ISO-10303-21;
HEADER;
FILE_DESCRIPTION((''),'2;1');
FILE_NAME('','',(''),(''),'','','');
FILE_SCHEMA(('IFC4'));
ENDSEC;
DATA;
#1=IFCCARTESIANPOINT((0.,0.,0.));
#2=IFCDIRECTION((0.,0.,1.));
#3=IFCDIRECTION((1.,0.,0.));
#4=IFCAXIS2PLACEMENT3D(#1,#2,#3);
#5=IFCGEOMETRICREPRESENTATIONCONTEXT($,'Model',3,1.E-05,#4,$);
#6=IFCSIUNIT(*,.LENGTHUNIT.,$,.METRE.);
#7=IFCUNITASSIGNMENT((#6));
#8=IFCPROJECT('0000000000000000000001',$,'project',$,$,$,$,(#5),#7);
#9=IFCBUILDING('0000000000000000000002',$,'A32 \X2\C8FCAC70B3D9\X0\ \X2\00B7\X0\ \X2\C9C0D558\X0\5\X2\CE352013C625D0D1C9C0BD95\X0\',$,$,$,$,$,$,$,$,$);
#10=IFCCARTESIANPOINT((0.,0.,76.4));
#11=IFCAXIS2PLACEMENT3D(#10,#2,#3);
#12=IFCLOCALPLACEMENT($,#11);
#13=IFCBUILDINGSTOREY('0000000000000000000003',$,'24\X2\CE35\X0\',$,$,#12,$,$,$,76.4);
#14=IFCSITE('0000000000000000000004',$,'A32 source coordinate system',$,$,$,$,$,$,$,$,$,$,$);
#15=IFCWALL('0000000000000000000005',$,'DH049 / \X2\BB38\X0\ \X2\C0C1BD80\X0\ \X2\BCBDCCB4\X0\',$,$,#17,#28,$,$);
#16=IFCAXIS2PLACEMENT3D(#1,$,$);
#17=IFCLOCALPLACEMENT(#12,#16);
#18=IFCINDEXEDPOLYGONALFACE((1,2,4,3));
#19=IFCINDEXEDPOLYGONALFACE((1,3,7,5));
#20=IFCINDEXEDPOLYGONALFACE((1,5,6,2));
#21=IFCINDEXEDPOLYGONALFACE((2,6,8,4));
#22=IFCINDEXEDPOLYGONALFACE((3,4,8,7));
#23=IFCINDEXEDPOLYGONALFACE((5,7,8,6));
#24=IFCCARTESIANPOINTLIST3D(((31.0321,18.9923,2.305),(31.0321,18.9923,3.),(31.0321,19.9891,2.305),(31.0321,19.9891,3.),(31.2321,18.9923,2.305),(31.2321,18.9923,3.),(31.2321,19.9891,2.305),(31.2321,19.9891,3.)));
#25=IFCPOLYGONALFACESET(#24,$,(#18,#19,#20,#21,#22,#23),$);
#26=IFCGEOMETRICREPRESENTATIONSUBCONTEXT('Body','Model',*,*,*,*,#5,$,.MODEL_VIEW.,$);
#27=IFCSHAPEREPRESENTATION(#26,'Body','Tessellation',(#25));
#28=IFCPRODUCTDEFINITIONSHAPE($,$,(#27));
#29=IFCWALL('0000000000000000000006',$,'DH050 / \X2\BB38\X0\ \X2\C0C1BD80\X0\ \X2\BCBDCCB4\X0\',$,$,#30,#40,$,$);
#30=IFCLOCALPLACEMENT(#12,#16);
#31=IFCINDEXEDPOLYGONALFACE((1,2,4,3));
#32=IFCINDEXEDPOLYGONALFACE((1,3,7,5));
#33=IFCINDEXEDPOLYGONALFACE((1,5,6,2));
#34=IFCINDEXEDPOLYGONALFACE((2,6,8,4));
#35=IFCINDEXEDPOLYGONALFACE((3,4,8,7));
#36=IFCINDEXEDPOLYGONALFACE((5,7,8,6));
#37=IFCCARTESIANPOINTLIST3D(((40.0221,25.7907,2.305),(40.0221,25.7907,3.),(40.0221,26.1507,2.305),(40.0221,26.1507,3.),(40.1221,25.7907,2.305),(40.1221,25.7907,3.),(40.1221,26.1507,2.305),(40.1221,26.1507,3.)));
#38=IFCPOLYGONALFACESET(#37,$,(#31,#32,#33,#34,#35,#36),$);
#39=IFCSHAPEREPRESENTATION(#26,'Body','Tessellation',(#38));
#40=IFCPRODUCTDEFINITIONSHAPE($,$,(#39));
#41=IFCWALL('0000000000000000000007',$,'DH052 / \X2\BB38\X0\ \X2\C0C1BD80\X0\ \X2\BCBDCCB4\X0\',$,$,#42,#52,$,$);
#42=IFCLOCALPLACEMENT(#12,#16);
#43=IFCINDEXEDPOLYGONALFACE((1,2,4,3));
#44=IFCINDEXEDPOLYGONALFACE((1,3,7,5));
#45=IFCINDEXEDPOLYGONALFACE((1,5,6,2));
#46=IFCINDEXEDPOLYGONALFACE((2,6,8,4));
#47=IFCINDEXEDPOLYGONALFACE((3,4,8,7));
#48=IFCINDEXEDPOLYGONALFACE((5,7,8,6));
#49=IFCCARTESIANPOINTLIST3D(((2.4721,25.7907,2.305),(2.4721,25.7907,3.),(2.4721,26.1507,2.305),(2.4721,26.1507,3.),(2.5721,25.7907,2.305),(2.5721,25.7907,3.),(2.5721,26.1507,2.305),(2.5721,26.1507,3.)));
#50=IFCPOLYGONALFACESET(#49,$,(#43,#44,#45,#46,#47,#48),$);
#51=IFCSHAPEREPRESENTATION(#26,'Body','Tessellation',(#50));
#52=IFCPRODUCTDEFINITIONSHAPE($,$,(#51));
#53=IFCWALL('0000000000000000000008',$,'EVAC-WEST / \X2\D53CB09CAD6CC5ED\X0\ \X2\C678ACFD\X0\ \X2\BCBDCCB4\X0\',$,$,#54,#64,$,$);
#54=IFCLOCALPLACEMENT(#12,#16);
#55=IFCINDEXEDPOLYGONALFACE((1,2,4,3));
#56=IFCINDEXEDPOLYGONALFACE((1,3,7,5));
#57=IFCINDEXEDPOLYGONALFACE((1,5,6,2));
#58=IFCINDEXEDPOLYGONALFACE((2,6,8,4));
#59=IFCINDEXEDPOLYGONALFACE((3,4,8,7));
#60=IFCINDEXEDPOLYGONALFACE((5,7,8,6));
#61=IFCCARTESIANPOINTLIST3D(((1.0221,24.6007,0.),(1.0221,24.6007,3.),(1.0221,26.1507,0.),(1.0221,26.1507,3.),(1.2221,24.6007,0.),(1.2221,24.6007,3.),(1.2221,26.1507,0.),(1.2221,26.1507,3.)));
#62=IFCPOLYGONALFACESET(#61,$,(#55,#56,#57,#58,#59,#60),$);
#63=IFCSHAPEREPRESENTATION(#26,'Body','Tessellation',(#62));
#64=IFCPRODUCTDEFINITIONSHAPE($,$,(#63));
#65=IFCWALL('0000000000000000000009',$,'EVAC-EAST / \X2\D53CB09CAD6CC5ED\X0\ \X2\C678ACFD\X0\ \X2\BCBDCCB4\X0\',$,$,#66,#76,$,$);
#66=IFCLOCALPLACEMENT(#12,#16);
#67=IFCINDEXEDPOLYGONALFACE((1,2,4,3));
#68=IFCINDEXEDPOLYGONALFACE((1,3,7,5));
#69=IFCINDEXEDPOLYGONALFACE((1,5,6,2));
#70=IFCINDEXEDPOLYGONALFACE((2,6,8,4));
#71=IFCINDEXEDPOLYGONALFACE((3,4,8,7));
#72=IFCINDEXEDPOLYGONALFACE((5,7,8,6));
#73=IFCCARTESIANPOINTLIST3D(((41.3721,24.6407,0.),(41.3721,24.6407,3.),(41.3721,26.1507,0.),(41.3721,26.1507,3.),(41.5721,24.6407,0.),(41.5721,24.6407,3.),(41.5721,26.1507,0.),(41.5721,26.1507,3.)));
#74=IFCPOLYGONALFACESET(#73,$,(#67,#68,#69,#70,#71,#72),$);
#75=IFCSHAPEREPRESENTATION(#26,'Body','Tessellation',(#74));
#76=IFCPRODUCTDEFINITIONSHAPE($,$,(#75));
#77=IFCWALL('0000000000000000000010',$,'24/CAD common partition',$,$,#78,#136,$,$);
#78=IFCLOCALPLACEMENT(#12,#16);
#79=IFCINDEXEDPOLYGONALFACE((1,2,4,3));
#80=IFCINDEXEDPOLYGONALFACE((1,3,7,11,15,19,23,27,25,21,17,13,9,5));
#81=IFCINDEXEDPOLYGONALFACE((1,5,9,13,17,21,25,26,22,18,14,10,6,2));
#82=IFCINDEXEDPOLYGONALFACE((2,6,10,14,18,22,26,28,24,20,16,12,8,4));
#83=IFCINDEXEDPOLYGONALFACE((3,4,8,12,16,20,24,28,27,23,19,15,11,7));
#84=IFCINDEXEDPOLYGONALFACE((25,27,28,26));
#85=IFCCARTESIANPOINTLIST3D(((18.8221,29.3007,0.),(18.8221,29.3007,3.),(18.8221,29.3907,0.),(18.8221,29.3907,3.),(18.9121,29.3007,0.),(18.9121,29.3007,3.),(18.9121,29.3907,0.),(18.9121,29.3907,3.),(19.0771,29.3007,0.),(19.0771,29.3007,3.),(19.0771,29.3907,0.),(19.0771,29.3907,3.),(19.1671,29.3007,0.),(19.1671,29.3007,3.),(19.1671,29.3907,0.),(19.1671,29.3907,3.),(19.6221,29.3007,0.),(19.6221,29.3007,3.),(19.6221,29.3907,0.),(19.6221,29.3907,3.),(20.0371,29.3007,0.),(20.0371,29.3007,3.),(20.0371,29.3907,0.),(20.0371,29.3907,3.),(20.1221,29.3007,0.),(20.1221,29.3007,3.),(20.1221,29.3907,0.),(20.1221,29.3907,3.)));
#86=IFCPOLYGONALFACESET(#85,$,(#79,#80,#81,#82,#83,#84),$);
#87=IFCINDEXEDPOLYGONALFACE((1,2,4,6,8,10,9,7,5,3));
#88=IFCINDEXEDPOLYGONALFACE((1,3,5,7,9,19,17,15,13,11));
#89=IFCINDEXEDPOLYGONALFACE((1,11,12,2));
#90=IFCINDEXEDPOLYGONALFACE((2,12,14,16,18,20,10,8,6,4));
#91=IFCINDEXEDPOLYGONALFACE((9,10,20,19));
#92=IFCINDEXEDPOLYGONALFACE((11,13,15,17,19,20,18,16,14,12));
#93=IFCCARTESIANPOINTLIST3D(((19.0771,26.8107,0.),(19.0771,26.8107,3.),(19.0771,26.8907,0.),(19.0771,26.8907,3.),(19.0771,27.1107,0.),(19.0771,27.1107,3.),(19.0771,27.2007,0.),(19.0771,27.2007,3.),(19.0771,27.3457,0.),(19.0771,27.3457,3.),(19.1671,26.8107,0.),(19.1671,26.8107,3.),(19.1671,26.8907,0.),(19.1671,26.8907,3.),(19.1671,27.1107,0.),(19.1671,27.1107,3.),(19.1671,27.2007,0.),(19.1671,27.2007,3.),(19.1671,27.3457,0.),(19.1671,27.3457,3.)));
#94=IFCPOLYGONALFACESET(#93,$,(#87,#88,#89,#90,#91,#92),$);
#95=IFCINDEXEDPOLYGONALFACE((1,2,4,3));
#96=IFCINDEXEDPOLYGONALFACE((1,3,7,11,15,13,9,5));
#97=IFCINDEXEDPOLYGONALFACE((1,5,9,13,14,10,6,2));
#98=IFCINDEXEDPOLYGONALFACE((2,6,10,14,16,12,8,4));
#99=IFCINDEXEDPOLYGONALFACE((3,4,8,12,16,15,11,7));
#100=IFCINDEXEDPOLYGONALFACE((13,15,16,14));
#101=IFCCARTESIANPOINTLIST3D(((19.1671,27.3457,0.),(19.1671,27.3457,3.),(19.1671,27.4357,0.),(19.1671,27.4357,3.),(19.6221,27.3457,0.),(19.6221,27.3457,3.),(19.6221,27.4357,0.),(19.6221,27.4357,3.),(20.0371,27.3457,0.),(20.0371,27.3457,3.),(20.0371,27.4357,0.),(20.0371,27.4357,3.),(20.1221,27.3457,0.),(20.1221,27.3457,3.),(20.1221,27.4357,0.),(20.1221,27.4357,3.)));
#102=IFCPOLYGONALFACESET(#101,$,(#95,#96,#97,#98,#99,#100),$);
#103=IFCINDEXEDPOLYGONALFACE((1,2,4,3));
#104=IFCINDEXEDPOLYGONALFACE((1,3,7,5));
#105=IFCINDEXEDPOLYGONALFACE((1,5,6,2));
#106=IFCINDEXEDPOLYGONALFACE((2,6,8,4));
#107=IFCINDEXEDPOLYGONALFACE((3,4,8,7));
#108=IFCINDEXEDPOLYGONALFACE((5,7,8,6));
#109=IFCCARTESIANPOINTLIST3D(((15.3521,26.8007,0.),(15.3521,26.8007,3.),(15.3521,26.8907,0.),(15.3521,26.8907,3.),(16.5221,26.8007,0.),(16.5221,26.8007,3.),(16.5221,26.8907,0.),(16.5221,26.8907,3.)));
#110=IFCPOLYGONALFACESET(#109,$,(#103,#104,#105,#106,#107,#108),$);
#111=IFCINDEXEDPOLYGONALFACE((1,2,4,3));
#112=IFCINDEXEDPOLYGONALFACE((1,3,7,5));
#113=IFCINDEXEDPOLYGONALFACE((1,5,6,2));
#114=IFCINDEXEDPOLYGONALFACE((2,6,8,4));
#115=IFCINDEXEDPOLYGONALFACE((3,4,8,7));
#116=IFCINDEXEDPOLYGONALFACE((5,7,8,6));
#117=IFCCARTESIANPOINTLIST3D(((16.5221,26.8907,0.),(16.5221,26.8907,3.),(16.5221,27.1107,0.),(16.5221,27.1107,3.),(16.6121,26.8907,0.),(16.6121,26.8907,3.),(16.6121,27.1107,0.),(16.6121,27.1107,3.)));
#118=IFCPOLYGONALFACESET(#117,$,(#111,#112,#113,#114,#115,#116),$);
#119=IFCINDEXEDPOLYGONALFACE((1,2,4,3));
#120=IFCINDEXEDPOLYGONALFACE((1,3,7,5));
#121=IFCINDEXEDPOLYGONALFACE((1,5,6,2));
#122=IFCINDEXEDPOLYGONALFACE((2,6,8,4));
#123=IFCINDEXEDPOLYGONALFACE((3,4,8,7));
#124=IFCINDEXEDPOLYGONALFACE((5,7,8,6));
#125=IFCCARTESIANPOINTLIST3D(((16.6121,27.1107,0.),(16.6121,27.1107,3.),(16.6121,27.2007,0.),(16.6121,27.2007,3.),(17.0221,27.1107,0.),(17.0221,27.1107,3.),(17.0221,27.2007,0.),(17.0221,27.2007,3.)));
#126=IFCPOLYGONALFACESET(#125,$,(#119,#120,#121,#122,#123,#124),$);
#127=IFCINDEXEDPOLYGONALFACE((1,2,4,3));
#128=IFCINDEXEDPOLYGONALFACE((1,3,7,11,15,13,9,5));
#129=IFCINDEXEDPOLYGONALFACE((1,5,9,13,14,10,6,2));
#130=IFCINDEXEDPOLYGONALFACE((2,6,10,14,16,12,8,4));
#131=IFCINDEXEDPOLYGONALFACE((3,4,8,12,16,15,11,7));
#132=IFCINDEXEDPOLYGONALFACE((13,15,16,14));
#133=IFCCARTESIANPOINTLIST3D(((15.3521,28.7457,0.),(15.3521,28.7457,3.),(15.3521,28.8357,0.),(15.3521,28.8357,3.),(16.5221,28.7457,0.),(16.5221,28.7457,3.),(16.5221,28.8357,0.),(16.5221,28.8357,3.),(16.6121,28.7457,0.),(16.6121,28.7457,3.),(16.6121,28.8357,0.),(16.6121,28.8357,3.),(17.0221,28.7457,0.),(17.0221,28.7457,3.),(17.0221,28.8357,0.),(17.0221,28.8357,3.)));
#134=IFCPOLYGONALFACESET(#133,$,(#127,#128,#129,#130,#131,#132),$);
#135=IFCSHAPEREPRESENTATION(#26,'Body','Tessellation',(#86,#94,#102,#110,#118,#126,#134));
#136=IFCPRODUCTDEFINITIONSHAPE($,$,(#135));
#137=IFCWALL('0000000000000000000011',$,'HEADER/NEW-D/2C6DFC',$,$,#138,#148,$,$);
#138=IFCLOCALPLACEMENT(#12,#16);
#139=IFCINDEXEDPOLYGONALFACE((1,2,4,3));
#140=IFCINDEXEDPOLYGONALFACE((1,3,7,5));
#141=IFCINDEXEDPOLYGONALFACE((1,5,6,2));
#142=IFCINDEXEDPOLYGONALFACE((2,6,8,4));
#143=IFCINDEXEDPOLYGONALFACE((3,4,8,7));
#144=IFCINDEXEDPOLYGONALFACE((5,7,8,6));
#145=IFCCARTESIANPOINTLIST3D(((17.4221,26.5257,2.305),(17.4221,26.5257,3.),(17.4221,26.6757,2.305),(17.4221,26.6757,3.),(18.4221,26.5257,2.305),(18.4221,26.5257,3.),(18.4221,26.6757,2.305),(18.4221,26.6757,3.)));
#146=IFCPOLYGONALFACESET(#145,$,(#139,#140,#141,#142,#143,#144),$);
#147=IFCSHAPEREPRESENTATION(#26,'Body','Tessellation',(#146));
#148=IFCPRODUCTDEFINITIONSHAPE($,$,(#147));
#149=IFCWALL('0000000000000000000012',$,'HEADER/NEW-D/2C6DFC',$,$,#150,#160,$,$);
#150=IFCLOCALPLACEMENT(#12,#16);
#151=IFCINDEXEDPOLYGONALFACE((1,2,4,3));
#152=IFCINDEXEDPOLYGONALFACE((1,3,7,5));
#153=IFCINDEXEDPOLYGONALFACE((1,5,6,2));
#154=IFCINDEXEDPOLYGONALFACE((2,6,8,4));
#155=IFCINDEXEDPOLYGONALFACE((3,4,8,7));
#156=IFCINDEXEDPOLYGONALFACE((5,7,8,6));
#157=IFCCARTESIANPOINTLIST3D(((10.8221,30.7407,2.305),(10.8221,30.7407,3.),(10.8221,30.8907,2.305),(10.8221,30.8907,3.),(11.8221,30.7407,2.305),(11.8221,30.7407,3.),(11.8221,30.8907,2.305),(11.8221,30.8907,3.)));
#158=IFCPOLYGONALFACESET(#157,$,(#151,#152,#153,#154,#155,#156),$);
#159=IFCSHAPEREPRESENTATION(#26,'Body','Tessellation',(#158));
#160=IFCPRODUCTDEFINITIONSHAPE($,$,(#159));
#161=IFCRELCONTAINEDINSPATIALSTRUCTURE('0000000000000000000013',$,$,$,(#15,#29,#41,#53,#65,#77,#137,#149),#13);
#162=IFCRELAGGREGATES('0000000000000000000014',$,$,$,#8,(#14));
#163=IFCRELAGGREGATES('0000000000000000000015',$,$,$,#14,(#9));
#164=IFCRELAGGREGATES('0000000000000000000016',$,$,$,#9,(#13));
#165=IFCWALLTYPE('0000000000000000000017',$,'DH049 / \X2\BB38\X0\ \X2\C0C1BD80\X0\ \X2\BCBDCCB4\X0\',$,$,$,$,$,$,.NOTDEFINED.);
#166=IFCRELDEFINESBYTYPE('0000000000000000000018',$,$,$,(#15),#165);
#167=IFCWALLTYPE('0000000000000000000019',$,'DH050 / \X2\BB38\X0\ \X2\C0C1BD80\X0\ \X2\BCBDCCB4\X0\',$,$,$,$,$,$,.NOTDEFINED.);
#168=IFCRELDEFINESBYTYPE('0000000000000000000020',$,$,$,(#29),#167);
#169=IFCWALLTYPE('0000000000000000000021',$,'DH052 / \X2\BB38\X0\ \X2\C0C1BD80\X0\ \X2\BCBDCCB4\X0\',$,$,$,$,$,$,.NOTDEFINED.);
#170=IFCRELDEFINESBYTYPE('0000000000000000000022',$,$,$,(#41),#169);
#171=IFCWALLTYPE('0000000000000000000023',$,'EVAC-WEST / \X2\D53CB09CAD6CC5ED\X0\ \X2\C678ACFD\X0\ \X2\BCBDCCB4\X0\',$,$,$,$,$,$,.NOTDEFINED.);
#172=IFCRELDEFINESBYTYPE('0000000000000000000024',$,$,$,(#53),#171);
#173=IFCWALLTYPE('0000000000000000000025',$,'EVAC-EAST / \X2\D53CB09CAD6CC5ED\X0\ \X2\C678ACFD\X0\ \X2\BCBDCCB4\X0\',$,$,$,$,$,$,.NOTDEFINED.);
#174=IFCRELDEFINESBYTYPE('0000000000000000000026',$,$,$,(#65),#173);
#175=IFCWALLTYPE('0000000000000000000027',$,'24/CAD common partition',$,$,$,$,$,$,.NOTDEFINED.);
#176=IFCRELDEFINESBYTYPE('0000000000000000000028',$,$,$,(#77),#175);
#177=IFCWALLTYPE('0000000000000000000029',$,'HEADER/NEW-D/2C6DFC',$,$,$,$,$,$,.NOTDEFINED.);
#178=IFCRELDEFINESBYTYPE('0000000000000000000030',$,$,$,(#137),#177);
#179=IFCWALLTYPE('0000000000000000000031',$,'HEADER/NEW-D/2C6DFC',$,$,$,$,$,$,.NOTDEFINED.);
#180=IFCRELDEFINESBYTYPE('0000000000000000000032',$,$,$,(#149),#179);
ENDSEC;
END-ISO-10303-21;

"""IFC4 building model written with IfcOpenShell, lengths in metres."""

from ifc_helpers import new_model, si_unit, frame, origin, origin_with_axes, place, context, subcontext, project, spatial, polyline, outline, extrude, source, transform, mapped, type_object, type_shapes, element, save


model = new_model("IFC4")

# Units and contexts
model_context = context("Model", 3, precision=1e-05, world=origin_with_axes())
body_context = subcontext(model_context, "Body", "Model", "MODEL_VIEW")
ifc_project = project(units=[si_unit("LENGTHUNIT", "METRE")], contexts=[model_context])

# Site, building, storey
site = spatial("IfcSite", under=ifc_project, Name="A32 source coordinate system")
building = spatial("IfcBuilding", under=site, Name="A32 주거동 · 지하5층–옥탑지붕")
storey_placement = place(None, frame((0.0, 0.0, 76.4), z_axis=(0.0, 0.0, 1.0), x_axis=(1.0, 0.0, 0.0)))
storey = spatial("IfcBuildingStorey", under=building, at=storey_placement, Name="24층", Elevation=76.4)

# Walls
wall_type_1 = type_object("IfcWallType", Name="DH049 / 문 상부 벽체", PredefinedType="NOTDEFINED")
shared_shape_1 = source(origin(), body_context, "Body", "SweptSolid", [
    extrude(outline(polyline([(31.2321, 18.9923), (31.0321, 18.9923), (31.0321, 19.9891), (31.2321, 19.9891), (31.2321, 18.9923)])), frame((0.0, 0.0, 2.305)), (0.0, 0.0, 1.0), 0.695),
])
type_shapes(wall_type_1, [shared_shape_1])
wall_1_placement = place(storey_placement, origin_with_axes())
element("IfcWall", 1, at=wall_1_placement, inside=storey, type_object=wall_type_1, Name="DH049 / 문 상부 벽체", context=body_context, shape_type="MappedRepresentation", body=[
    mapped(shared_shape_1, transform((0.0, 0.0, 0.0), scale=1.0)),
])
wall_type_2 = type_object("IfcWallType", Name="DH050 / 문 상부 벽체", PredefinedType="NOTDEFINED")
shared_shape_2 = source(origin(), body_context, "Body", "SweptSolid", [
    extrude(outline(polyline([(40.0221, 25.7907), (40.0221, 26.1507), (40.1221, 26.1507), (40.1221, 25.7907), (40.0221, 25.7907)])), frame((0.0, 0.0, 2.305)), (0.0, 0.0, 1.0), 0.695),
])
type_shapes(wall_type_2, [shared_shape_2])
wall_2_placement = place(storey_placement, origin_with_axes())
element("IfcWall", 2, at=wall_2_placement, inside=storey, type_object=wall_type_2, Name="DH050 / 문 상부 벽체", context=body_context, shape_type="MappedRepresentation", body=[
    mapped(shared_shape_2, transform((0.0, 0.0, 0.0), scale=1.0)),
])
wall_type_3 = type_object("IfcWallType", Name="DH052 / 문 상부 벽체", PredefinedType="NOTDEFINED")
shared_shape_3 = source(origin(), body_context, "Body", "SweptSolid", [
    extrude(outline(polyline([(2.5721, 25.7907), (2.4721, 25.7907), (2.4721, 26.1507), (2.5721, 26.1507), (2.5721, 25.7907)])), frame((0.0, 0.0, 2.305)), (0.0, 0.0, 1.0), 0.695),
])
type_shapes(wall_type_3, [shared_shape_3])
wall_3_placement = place(storey_placement, origin_with_axes())
element("IfcWall", 3, at=wall_3_placement, inside=storey, type_object=wall_type_3, Name="DH052 / 문 상부 벽체", context=body_context, shape_type="MappedRepresentation", body=[
    mapped(shared_shape_3, transform((0.0, 0.0, 0.0), scale=1.0)),
])
wall_type_4 = type_object("IfcWallType", Name="EVAC-WEST / 피난구역 외곽 벽체", PredefinedType="NOTDEFINED")
shared_shape_4 = source(origin(), body_context, "Body", "SweptSolid", [
    extrude(outline(polyline([(1.2221, 24.6007), (1.0221, 24.6007), (1.0221, 26.1507), (1.2221, 26.1507), (1.2221, 24.6007)])), origin(), (0.0, 0.0, 1.0), 3.0),
])
type_shapes(wall_type_4, [shared_shape_4])
wall_4_placement = place(storey_placement, origin_with_axes())
element("IfcWall", 4, at=wall_4_placement, inside=storey, type_object=wall_type_4, Name="EVAC-WEST / 피난구역 외곽 벽체", context=body_context, shape_type="MappedRepresentation", body=[
    mapped(shared_shape_4, transform((0.0, 0.0, 0.0), scale=1.0)),
])
wall_type_5 = type_object("IfcWallType", Name="EVAC-EAST / 피난구역 외곽 벽체", PredefinedType="NOTDEFINED")
shared_shape_5 = source(origin(), body_context, "Body", "SweptSolid", [
    extrude(outline(polyline([(41.5721, 26.1507), (41.5721, 24.6407), (41.3721, 24.6407), (41.3721, 26.1507), (41.5721, 26.1507)])), origin(), (0.0, 0.0, 1.0), 3.0),
])
type_shapes(wall_type_5, [shared_shape_5])
wall_5_placement = place(storey_placement, origin_with_axes())
element("IfcWall", 5, at=wall_5_placement, inside=storey, type_object=wall_type_5, Name="EVAC-EAST / 피난구역 외곽 벽체", context=body_context, shape_type="MappedRepresentation", body=[
    mapped(shared_shape_5, transform((0.0, 0.0, 0.0), scale=1.0)),
])
wall_type_6 = type_object("IfcWallType", Name="24/CAD common partition", PredefinedType="NOTDEFINED")
shared_shape_6 = source(origin(), body_context, "Body", "SweptSolid", [
    extrude(outline(polyline([(18.9121, 29.3907), (19.0771, 29.3907), (19.1671, 29.3907), (19.6221, 29.3907), (20.0371, 29.3907), (20.1221, 29.3907), (20.1221, 29.3007), (20.0371, 29.3007), (19.6221, 29.3007), (19.1671, 29.3007), (19.0771, 29.3007), (18.9121, 29.3007), (18.8221, 29.3007), (18.8221, 29.3907), (18.9121, 29.3907)])), origin(), (0.0, 0.0, 1.0), 3.0),
    extrude(outline(polyline([(19.0771, 26.8107), (19.0771, 26.8907), (19.0771, 27.1107), (19.0771, 27.2007), (19.0771, 27.3457), (19.1671, 27.3457), (19.1671, 27.2007), (19.1671, 27.1107), (19.1671, 26.8907), (19.1671, 26.8107), (19.0771, 26.8107)])), origin(), (0.0, 0.0, 1.0), 3.0),
    extrude(outline(polyline([(19.1671, 27.3457), (19.1671, 27.4357), (19.6221, 27.4357), (20.0371, 27.4357), (20.1221, 27.4357), (20.1221, 27.3457), (20.0371, 27.3457), (19.6221, 27.3457), (19.1671, 27.3457)])), origin(), (0.0, 0.0, 1.0), 3.0),
    extrude(outline(polyline([(15.3521, 26.8907), (16.5221, 26.8907), (16.5221, 26.8007), (15.3521, 26.8007), (15.3521, 26.8907)])), origin(), (0.0, 0.0, 1.0), 3.0),
    extrude(outline(polyline([(16.5221, 26.8907), (16.5221, 27.1107), (16.6121, 27.1107), (16.6121, 26.8907), (16.5221, 26.8907)])), origin(), (0.0, 0.0, 1.0), 3.0),
    extrude(outline(polyline([(16.6121, 27.1107), (16.6121, 27.2007), (17.0221, 27.2007), (17.0221, 27.1107), (16.6121, 27.1107)])), origin(), (0.0, 0.0, 1.0), 3.0),
    extrude(outline(polyline([(17.0221, 28.7457), (16.6121, 28.7457), (16.5221, 28.7457), (15.3521, 28.7457), (15.3521, 28.8357), (16.5221, 28.8357), (16.6121, 28.8357), (17.0221, 28.8357), (17.0221, 28.7457)])), origin(), (0.0, 0.0, 1.0), 3.0),
])
type_shapes(wall_type_6, [shared_shape_6])
wall_6_placement = place(storey_placement, origin_with_axes())
element("IfcWall", 6, at=wall_6_placement, inside=storey, type_object=wall_type_6, Name="24/CAD common partition", context=body_context, shape_type="MappedRepresentation", body=[
    mapped(shared_shape_6, transform((0.0, 0.0, 0.0), scale=1.0)),
])
wall_type_7 = type_object("IfcWallType", Name="HEADER/NEW-D/2C6DFC", PredefinedType="NOTDEFINED")
shared_shape_7 = source(origin(), body_context, "Body", "SweptSolid", [
    extrude(outline(polyline([(17.4221, 26.5257), (17.4221, 26.6757), (18.4221, 26.6757), (18.4221, 26.5257), (17.4221, 26.5257)])), frame((0.0, 0.0, 2.305)), (0.0, 0.0, 1.0), 0.695),
])
type_shapes(wall_type_7, [shared_shape_7])
wall_7_placement = place(storey_placement, origin_with_axes())
element("IfcWall", 7, at=wall_7_placement, inside=storey, type_object=wall_type_7, Name="HEADER/NEW-D/2C6DFC", context=body_context, shape_type="MappedRepresentation", body=[
    mapped(shared_shape_7, transform((0.0, 0.0, 0.0), scale=1.0)),
])
wall_type_8 = type_object("IfcWallType", Name="HEADER/NEW-D/2C6DFC", PredefinedType="NOTDEFINED")
shared_shape_8 = source(origin(), body_context, "Body", "SweptSolid", [
    extrude(outline(polyline([(10.8221, 30.7407), (10.8221, 30.8907), (11.8221, 30.8907), (11.8221, 30.7407), (10.8221, 30.7407)])), frame((0.0, 0.0, 2.305)), (0.0, 0.0, 1.0), 0.695),
])
type_shapes(wall_type_8, [shared_shape_8])
wall_8_placement = place(storey_placement, origin_with_axes())
element("IfcWall", 8, at=wall_8_placement, inside=storey, type_object=wall_type_8, Name="HEADER/NEW-D/2C6DFC", context=body_context, shape_type="MappedRepresentation", body=[
    mapped(shared_shape_8, transform((0.0, 0.0, 0.0), scale=1.0)),
])

save(model, "model.ifc")
